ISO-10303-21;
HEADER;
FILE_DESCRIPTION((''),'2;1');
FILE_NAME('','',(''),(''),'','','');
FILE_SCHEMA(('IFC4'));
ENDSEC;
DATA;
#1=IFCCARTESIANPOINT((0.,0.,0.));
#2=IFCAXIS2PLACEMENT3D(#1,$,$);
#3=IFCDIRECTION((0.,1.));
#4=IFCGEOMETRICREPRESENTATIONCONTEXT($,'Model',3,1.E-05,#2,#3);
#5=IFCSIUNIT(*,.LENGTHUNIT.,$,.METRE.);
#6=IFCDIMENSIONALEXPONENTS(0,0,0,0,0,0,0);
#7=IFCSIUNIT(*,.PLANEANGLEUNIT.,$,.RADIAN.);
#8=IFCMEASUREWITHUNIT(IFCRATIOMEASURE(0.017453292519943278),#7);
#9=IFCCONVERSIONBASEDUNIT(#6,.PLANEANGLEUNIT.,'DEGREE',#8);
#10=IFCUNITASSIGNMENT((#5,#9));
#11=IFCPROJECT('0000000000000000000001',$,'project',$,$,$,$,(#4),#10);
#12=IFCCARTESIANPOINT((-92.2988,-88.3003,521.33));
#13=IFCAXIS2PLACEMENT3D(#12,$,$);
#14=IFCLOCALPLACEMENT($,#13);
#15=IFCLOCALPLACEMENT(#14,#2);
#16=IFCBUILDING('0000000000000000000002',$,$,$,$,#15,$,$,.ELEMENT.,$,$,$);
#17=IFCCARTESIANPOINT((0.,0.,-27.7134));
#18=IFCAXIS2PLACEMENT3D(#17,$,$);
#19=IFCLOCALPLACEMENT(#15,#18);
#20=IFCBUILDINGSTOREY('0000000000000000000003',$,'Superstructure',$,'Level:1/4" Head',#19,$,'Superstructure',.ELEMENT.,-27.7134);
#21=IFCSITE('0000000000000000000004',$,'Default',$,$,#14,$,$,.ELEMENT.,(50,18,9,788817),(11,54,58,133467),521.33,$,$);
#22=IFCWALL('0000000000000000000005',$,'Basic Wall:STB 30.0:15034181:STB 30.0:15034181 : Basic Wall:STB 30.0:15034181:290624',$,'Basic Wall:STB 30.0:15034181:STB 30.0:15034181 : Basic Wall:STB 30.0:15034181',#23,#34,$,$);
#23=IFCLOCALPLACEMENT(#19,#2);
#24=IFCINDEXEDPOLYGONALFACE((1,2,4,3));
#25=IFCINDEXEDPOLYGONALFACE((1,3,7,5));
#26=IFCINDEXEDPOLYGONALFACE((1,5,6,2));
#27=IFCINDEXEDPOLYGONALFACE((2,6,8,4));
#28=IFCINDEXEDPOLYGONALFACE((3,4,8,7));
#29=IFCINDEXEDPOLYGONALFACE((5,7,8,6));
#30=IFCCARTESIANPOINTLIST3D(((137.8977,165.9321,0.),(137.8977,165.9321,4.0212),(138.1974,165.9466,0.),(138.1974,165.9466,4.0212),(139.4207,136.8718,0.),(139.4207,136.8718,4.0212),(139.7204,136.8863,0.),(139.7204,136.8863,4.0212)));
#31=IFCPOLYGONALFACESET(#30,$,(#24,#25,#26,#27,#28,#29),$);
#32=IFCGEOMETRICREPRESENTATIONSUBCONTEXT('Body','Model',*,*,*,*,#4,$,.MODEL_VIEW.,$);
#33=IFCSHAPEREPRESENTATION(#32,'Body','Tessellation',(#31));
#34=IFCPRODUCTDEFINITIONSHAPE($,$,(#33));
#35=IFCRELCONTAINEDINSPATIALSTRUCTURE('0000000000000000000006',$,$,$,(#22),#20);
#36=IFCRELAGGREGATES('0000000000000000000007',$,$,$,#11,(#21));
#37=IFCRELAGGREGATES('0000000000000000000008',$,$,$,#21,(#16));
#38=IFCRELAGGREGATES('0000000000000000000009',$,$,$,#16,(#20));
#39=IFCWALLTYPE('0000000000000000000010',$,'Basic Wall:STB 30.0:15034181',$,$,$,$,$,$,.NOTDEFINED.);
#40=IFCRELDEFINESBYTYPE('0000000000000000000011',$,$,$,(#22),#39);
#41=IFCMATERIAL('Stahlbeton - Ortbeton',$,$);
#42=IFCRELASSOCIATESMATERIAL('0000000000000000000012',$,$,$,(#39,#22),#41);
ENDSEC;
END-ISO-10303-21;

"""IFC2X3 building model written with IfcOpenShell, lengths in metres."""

from ifc_helpers import new_model, entity, si_unit, converted_unit, direction, frame, origin, place, context, subcontext, project, spatial, polyline, outline, extrude, material, type_object, element, save


model = new_model("IFC2X3")

# Units and contexts
model_context = context("Model", 3, precision=1e-05, world=origin(), true_north=direction((0.0, 1.0)))
body_context = subcontext(model_context, "Body", "Model", "MODEL_VIEW")
ifc_project = project(units=[si_unit("LENGTHUNIT", "METRE"), converted_unit("PLANEANGLEUNIT", "DEGREE", entity("IfcRatioMeasure", 0.017453292519943278), si_unit("PLANEANGLEUNIT", "RADIAN"), dimensions=[0, 0, 0, 0, 0, 0, 0])], contexts=[model_context])

# Site, building, storey
site_placement = place(None, frame((-92.2988, -88.3003, 521.33)))
site = spatial("IfcSite", under=ifc_project, at=site_placement, Name="Default", CompositionType="ELEMENT", RefLatitude=(50, 18, 9, 788817), RefLongitude=(11, 54, 58, 133467), RefElevation=521.33)
building_placement = place(site_placement, origin())
building = spatial("IfcBuilding", under=site, at=building_placement, CompositionType="ELEMENT")
storey_placement = place(building_placement, frame((0.0, 0.0, -27.7134)))
storey = spatial("IfcBuildingStorey", under=building, at=storey_placement, Name="Superstructure", ObjectType="Level:1/4\" Head", LongName="Superstructure", CompositionType="ELEMENT", Elevation=-27.7134)

# Wall
ifc_material_1 = material(Name="Stahlbeton - Ortbeton")
wall_type = type_object("IfcWallType", Name="Basic Wall:STB 30.0:15034181", PredefinedType="NOTDEFINED", material=ifc_material_1)
wall_placement = place(storey_placement, frame((137.8977, 136.8718, 0.0), z_axis=(0.0, 0.0, 1.0), x_axis=(0.0, 1.0, 0.0)))
element("IfcWall", 1, at=wall_placement, inside=storey, type_object=wall_type, material=ifc_material_1, Name="Basic Wall:STB 30.0:15034181:STB 30.0:15034181 : Basic Wall:STB 30.0:15034181:290624", ObjectType="Basic Wall:STB 30.0:15034181:STB 30.0:15034181 : Basic Wall:STB 30.0:15034181", context=body_context, shape_type="SweptSolid", body=[
    extrude(outline(polyline([(-14.5507, -0.15), (14.5495, -0.15), (14.5507, 0.15), (-14.5495, 0.15), (-14.5507, -0.15)])), frame((14.5374, -0.9113, 0.0), z_axis=(0.0, 0.0, 1.0), x_axis=(0.99863, 0.052336, 0.0)), (0.0, 0.0, 1.0), 4.0212),
])

save(model, "model.ifc")
